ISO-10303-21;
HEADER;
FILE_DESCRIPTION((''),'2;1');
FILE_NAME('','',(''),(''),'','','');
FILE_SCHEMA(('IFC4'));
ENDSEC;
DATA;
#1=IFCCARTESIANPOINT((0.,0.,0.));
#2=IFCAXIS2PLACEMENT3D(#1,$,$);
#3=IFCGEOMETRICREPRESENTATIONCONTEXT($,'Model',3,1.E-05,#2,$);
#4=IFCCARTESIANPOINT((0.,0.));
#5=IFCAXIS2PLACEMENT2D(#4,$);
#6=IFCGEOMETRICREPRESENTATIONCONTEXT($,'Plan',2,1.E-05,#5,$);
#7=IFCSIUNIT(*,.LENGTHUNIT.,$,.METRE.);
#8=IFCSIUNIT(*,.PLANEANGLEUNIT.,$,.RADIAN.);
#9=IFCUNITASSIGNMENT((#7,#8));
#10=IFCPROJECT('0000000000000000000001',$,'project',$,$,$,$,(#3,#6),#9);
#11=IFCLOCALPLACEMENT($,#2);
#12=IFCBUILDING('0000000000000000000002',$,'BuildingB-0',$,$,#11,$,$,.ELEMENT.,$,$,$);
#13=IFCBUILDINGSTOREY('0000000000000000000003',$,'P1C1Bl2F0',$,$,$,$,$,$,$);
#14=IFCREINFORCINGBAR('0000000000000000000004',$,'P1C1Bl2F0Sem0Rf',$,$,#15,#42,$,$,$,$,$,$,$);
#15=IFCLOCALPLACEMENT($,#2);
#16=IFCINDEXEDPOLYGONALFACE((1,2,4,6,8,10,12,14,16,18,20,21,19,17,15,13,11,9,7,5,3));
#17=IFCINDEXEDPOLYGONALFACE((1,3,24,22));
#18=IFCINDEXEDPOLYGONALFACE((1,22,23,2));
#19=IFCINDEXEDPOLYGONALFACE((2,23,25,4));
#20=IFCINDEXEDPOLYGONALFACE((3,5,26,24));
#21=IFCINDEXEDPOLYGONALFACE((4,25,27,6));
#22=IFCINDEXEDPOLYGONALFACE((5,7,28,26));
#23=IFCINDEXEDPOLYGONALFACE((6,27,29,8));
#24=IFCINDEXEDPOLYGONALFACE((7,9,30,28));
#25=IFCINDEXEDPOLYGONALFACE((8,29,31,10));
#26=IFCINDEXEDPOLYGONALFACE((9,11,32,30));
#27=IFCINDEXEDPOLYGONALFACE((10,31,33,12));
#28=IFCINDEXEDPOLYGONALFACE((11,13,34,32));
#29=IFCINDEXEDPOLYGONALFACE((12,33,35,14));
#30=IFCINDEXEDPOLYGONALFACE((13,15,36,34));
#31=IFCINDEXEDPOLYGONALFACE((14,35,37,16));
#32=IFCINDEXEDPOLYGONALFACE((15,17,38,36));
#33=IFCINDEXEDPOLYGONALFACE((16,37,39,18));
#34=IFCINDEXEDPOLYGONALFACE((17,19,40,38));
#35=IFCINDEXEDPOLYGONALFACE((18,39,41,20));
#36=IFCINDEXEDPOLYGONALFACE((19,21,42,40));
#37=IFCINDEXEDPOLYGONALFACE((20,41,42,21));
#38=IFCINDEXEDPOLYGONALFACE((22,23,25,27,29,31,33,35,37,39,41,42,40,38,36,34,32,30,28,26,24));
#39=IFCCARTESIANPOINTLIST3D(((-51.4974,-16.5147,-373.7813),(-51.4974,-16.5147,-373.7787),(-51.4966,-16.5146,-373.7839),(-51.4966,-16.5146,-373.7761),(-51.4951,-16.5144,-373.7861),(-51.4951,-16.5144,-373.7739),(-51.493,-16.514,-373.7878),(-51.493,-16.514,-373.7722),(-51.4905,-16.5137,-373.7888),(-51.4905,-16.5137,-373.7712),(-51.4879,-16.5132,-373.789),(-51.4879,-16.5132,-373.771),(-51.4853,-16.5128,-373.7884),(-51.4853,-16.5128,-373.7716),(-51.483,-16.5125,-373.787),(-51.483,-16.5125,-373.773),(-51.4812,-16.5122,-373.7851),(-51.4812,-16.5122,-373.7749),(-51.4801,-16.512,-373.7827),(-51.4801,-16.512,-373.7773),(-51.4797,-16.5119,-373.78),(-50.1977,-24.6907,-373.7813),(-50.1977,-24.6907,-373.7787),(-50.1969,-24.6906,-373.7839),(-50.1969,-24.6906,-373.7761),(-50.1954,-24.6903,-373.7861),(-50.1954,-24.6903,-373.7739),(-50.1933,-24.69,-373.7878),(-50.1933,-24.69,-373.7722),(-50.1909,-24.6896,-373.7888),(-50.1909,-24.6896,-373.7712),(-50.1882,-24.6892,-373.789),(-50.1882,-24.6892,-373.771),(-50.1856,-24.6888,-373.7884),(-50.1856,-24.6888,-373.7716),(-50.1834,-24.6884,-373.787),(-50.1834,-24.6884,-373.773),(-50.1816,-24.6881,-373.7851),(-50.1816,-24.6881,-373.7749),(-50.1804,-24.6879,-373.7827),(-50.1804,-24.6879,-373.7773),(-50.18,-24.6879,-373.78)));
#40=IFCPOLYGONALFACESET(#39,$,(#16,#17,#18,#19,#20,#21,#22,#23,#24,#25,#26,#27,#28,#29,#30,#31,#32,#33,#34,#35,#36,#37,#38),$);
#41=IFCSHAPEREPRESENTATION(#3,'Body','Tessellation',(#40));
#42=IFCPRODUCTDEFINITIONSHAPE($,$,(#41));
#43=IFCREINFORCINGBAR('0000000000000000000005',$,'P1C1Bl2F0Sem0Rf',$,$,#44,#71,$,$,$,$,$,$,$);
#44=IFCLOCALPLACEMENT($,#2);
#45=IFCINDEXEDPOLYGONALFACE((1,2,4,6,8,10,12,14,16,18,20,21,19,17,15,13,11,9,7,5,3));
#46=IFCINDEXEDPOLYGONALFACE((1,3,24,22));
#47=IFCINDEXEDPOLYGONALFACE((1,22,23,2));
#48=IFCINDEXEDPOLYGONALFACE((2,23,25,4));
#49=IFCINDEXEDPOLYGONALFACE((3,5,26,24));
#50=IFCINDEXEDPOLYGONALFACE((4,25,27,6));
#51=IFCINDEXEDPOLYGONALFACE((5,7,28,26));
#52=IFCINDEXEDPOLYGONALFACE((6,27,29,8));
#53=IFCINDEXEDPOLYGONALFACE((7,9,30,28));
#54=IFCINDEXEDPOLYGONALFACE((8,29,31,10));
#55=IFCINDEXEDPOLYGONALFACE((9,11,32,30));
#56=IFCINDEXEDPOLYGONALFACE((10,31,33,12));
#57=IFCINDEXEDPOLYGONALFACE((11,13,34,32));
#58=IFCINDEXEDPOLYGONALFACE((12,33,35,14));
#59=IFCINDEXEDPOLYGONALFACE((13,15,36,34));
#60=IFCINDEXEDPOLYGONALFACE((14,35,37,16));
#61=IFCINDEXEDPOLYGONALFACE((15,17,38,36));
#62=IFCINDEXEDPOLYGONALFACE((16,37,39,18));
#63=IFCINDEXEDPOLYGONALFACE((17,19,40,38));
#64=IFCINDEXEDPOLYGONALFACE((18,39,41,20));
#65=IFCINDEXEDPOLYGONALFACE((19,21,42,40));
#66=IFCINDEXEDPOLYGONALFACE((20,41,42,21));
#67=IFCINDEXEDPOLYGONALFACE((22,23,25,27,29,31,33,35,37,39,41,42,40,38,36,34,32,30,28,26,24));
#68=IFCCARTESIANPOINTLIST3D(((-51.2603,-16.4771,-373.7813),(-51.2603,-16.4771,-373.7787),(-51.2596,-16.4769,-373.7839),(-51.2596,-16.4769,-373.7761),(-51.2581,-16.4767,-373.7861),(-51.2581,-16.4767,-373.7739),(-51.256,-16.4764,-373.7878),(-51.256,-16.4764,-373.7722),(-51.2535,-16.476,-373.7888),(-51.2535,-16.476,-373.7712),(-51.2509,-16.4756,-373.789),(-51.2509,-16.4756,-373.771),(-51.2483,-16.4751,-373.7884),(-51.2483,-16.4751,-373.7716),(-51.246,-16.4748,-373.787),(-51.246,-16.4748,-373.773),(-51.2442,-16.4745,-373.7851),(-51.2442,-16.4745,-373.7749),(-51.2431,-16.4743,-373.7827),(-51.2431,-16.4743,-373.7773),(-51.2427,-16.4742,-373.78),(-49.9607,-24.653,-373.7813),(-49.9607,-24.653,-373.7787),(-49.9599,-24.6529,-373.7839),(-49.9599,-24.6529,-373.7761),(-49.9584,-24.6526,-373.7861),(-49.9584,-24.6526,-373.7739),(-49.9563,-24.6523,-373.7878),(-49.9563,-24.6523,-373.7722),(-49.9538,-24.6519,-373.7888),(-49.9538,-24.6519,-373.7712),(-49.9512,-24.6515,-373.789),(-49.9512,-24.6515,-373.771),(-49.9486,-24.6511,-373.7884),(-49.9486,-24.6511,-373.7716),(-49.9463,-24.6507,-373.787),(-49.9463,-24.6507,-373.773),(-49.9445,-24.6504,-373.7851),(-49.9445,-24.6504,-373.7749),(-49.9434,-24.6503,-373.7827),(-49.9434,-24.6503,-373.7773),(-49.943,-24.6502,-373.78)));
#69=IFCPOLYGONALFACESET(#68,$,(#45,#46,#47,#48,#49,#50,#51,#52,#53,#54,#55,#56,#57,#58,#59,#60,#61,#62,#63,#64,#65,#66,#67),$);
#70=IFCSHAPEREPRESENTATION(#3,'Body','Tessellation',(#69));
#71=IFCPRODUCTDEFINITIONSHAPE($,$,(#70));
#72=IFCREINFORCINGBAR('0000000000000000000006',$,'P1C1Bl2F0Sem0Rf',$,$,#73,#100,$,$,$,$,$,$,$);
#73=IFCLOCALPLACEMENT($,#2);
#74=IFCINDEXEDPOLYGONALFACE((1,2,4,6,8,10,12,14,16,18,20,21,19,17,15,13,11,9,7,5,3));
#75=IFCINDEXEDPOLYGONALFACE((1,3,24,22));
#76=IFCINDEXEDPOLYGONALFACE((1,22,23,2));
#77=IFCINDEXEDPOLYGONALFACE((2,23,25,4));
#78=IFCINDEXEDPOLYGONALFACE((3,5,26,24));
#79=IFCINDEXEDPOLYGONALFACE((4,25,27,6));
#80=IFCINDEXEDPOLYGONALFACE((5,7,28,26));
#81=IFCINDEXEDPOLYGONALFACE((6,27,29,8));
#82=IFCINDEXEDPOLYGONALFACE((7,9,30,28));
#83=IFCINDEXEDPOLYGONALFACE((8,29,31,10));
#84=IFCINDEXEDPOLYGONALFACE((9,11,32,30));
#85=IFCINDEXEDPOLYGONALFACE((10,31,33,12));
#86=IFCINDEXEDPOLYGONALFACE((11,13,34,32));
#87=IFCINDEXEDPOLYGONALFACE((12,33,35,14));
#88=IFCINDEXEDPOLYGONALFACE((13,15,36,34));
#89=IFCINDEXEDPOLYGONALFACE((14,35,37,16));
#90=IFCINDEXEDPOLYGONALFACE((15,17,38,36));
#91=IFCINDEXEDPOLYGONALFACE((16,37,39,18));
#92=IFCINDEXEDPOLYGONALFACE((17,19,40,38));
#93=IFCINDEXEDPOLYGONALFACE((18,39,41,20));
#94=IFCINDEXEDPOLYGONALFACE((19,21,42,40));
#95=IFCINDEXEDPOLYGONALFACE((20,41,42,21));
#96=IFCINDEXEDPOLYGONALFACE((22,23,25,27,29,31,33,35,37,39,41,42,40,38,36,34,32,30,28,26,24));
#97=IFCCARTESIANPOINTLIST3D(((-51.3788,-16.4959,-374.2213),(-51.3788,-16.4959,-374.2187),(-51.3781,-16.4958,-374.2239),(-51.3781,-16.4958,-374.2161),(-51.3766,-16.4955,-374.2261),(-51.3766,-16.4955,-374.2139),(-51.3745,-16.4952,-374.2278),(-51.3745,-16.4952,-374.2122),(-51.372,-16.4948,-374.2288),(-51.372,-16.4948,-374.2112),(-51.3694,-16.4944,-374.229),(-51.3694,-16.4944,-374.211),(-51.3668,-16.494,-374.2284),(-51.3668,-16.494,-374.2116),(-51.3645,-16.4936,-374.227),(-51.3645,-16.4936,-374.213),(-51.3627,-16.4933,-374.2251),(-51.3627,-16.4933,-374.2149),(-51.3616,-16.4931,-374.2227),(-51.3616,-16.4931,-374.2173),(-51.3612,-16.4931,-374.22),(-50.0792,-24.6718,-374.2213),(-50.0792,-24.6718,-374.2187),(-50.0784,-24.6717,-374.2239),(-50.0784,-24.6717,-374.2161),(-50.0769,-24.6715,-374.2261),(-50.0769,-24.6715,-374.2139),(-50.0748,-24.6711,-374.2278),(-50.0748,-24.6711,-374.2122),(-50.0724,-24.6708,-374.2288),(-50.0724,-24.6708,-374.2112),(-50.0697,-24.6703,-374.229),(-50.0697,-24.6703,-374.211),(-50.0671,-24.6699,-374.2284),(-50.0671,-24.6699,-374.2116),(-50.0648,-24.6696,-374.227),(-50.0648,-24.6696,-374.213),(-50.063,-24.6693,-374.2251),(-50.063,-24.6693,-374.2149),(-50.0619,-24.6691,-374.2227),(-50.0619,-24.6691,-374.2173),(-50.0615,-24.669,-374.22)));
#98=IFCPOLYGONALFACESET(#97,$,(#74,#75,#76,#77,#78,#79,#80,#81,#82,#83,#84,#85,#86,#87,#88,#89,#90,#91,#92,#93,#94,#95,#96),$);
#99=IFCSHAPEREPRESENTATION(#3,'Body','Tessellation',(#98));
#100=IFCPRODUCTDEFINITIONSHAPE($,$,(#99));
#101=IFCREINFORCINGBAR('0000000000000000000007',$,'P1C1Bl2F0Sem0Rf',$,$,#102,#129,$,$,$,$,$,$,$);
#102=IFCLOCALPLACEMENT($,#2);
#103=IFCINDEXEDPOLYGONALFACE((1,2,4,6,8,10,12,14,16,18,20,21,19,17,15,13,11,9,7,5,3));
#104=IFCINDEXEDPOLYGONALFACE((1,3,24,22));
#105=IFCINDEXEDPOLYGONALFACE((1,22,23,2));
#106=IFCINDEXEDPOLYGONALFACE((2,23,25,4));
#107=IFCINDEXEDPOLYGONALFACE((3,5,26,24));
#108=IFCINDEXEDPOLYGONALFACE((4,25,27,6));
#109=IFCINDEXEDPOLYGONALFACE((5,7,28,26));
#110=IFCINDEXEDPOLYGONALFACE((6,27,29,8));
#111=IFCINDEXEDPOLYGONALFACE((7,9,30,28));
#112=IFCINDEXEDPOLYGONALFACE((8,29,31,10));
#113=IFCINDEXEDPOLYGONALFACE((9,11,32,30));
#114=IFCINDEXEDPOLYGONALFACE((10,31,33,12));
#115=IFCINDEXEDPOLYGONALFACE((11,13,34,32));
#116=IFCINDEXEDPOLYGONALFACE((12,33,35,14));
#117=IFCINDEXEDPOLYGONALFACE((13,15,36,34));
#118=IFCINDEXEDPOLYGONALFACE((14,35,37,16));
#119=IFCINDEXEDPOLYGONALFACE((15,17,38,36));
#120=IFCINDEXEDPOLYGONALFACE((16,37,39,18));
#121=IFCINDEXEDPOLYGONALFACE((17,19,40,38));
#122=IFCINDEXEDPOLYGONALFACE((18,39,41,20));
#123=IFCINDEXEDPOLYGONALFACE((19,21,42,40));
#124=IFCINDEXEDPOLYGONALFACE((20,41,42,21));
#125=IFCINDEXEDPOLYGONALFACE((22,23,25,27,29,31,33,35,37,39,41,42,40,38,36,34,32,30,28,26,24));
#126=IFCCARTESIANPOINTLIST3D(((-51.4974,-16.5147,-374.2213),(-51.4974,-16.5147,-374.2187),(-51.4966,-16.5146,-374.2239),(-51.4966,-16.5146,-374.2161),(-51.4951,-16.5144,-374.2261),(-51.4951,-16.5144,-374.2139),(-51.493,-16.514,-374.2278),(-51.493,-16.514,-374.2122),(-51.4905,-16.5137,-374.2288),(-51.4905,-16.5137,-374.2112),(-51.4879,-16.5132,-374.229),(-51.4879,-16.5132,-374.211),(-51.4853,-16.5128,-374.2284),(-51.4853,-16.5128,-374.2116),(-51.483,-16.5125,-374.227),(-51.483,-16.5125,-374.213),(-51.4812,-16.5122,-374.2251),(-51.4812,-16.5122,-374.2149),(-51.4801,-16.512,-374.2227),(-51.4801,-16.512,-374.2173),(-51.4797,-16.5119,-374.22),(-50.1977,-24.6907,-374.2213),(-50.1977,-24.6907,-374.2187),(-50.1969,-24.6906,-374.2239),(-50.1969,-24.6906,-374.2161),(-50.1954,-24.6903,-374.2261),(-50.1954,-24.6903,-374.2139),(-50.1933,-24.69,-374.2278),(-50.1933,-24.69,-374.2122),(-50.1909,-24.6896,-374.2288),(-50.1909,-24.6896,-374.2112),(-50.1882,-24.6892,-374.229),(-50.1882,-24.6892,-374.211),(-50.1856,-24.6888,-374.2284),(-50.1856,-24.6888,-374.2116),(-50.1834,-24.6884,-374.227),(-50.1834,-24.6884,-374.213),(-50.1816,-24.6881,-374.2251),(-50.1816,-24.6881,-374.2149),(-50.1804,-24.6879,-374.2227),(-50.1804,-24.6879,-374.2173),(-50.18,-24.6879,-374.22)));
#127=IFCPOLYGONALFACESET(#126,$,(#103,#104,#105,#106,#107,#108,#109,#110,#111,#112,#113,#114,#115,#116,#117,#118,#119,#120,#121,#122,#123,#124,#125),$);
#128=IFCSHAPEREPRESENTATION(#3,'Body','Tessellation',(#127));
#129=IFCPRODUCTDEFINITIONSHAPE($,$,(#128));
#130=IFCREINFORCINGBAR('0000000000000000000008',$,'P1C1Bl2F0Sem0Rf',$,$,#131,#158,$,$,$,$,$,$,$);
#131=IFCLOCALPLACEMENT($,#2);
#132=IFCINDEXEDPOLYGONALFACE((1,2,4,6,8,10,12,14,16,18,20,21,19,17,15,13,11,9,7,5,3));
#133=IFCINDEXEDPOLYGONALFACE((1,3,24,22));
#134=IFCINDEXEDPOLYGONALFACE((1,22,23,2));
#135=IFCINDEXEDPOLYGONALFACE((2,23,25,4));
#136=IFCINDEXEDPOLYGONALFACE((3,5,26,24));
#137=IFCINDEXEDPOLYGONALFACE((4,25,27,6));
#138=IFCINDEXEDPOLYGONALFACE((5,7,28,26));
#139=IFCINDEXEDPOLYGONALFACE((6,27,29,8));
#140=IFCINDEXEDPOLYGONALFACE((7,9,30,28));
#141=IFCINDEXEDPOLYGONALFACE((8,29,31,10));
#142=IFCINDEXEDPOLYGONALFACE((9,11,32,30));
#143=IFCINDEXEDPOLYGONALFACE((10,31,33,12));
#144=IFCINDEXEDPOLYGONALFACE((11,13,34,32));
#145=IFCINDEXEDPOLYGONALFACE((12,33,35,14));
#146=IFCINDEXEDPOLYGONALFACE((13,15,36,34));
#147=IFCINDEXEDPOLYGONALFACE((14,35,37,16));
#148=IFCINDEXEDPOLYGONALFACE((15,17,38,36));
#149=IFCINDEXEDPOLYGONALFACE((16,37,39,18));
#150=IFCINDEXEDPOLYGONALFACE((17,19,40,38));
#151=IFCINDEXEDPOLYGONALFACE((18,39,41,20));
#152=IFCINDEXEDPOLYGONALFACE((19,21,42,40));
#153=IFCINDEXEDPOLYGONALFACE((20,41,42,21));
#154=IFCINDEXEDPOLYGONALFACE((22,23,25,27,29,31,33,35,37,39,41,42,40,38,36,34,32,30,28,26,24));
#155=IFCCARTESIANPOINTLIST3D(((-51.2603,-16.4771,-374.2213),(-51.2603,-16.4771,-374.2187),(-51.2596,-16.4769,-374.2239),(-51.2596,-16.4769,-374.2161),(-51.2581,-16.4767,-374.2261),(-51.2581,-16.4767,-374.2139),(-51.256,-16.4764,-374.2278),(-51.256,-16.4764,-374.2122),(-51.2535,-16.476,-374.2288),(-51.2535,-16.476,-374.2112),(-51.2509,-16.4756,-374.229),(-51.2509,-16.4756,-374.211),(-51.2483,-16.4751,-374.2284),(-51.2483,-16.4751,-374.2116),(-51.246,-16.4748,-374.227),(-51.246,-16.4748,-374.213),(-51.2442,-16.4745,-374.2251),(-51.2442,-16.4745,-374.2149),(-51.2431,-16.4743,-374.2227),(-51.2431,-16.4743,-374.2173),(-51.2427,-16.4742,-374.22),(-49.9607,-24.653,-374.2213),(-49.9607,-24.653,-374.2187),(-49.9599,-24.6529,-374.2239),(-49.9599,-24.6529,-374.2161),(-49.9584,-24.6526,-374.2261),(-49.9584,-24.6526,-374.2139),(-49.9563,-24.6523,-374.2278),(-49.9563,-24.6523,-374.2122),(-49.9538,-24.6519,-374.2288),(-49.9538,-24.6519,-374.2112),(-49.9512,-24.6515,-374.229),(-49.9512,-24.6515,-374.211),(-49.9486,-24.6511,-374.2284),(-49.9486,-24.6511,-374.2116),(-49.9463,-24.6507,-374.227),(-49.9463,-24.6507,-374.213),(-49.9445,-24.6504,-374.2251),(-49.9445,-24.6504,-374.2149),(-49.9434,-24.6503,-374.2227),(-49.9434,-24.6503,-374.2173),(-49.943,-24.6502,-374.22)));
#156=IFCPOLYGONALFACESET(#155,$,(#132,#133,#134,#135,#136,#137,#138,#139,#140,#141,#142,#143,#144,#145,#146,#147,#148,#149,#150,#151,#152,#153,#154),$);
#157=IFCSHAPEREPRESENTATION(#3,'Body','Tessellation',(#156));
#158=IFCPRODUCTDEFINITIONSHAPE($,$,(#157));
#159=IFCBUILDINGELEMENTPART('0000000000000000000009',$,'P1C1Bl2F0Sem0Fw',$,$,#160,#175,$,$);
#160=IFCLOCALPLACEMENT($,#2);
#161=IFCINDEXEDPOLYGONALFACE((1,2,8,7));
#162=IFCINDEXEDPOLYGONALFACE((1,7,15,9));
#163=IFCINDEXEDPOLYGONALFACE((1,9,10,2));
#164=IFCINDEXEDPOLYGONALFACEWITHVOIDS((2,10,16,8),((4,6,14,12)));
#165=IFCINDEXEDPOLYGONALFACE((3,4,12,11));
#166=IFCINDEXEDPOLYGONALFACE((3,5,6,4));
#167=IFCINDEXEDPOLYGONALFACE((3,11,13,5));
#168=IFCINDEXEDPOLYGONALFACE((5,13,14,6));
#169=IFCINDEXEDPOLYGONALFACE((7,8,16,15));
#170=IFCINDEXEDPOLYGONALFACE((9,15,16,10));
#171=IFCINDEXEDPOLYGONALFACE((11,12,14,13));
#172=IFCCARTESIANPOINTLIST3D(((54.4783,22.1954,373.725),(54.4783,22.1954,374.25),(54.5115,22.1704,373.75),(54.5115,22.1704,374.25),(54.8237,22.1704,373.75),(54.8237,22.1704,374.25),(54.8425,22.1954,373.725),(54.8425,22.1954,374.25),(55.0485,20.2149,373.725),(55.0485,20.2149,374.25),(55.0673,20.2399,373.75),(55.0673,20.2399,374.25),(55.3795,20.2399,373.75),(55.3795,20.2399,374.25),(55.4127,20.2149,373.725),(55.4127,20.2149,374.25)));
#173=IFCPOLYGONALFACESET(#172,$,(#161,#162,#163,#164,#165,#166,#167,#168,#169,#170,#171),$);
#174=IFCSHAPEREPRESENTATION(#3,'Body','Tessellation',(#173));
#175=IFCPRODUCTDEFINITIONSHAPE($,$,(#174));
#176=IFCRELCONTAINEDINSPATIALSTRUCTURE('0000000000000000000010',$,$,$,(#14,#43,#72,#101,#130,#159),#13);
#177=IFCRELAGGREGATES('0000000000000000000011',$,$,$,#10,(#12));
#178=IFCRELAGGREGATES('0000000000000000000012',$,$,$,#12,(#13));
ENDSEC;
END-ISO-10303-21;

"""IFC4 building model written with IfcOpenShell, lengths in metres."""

from ifc_helpers import new_model, entity, si_unit, origin, origin_2d, place, context, project, spatial, polyline, outline, extrude, element, save


model = new_model("IFC4")

# Units and contexts
model_context = context("Model", 3, precision=1e-05, world=origin())
plan_context = context("Plan", 2, precision=1e-05, world=origin_2d())
ifc_project = project(units=[si_unit("LENGTHUNIT", "METRE"), si_unit("PLANEANGLEUNIT", "RADIAN")], contexts=[model_context, plan_context])

# Building, storey
building_placement = place(None, origin())
building = spatial("IfcBuilding", under=ifc_project, at=building_placement, Name="BuildingB-0", CompositionType="ELEMENT")
storey = spatial("IfcBuildingStorey", under=building, Name="P1C1Bl2F0")

# Reinforcing bars
element("IfcReinforcingBar", 1, inside=storey, Name="P1C1Bl2F0Sem0Rf", context=model_context, shape_type="SweptSolid", body=[
    entity("IfcSurfaceCurveSweptAreaSolid", entity("IfcCircleProfileDef", "AREA", None, None, 0.009), None, entity("IfcPolyline", [entity("IfcCartesianPoint", [51.4886, 16.5133, 373.78]), entity("IfcCartesianPoint", [50.1889, 24.6893, 373.78])]), None, None, entity("IfcPlane", entity("IfcAxis2Placement3D", entity("IfcCartesianPoint", [51.4886, 16.5133, 373.78]), entity("IfcDirection", [0.0, 0.0, 1.0]), entity("IfcDirection", [1.0, 0.0, 0.0])))),
])
element("IfcReinforcingBar", 2, inside=storey, Name="P1C1Bl2F0Sem0Rf", context=model_context, shape_type="SweptSolid", body=[
    entity("IfcSurfaceCurveSweptAreaSolid", entity("IfcCircleProfileDef", "AREA", None, None, 0.009), None, entity("IfcPolyline", [entity("IfcCartesianPoint", [51.2515, 16.4757, 373.78]), entity("IfcCartesianPoint", [49.9519, 24.6516, 373.78])]), None, None, entity("IfcPlane", entity("IfcAxis2Placement3D", entity("IfcCartesianPoint", [51.2515, 16.4757, 373.78]), entity("IfcDirection", [0.0, 0.0, 1.0]), entity("IfcDirection", [1.0, 0.0, 0.0])))),
])
element("IfcReinforcingBar", 3, inside=storey, Name="P1C1Bl2F0Sem0Rf", context=model_context, shape_type="SweptSolid", body=[
    entity("IfcSurfaceCurveSweptAreaSolid", entity("IfcCircleProfileDef", "AREA", None, None, 0.009), None, entity("IfcPolyline", [entity("IfcCartesianPoint", [51.3701, 16.4945, 374.22]), entity("IfcCartesianPoint", [50.0704, 24.6704, 374.22])]), None, None, entity("IfcPlane", entity("IfcAxis2Placement3D", entity("IfcCartesianPoint", [51.3701, 16.4945, 374.22]), entity("IfcDirection", [0.0, 0.0, 1.0]), entity("IfcDirection", [1.0, 0.0, 0.0])))),
])
element("IfcReinforcingBar", 4, inside=storey, Name="P1C1Bl2F0Sem0Rf", context=model_context, shape_type="SweptSolid", body=[
    entity("IfcSurfaceCurveSweptAreaSolid", entity("IfcCircleProfileDef", "AREA", None, None, 0.009), None, entity("IfcPolyline", [entity("IfcCartesianPoint", [51.4886, 16.5133, 374.22]), entity("IfcCartesianPoint", [50.1889, 24.6893, 374.22])]), None, None, entity("IfcPlane", entity("IfcAxis2Placement3D", entity("IfcCartesianPoint", [51.4886, 16.5133, 374.22]), entity("IfcDirection", [0.0, 0.0, 1.0]), entity("IfcDirection", [1.0, 0.0, 0.0])))),
])
element("IfcReinforcingBar", 5, inside=storey, Name="P1C1Bl2F0Sem0Rf", context=model_context, shape_type="SweptSolid", body=[
    entity("IfcSurfaceCurveSweptAreaSolid", entity("IfcCircleProfileDef", "AREA", None, None, 0.009), None, entity("IfcPolyline", [entity("IfcCartesianPoint", [51.2515, 16.4757, 374.22]), entity("IfcCartesianPoint", [49.9519, 24.6516, 374.22])]), None, None, entity("IfcPlane", entity("IfcAxis2Placement3D", entity("IfcCartesianPoint", [51.2515, 16.4757, 374.22]), entity("IfcDirection", [0.0, 0.0, 1.0]), entity("IfcDirection", [1.0, 0.0, 0.0])))),
])

# Building element part, opening
building_element_part_1 = element("IfcBuildingElementPart", 6, inside=storey, Name="P1C1Bl2F0Sem0Fw", context=model_context, shape_type="SweptSolid", body=[
    extrude(outline(polyline([(55.0485, 20.2149, 373.725), (55.4127, 20.2149, 373.725), (54.8425, 22.1954, 373.725), (54.4783, 22.1954, 373.725), (55.0485, 20.2149, 373.725)])), None, (0.0, 0.0, 1.0), 0.525),
])
element("IfcOpeningElement", 7, inside=storey, cuts=building_element_part_1, context=model_context, shape_type="SweptSolid", body=[
    extrude(outline(polyline([(55.0673, 20.2399, 373.75), (55.3795, 20.2399, 373.75), (54.8237, 22.1704, 373.75), (54.5115, 22.1704, 373.75), (55.0673, 20.2399, 373.75)])), None, (0.0, 0.0, 1.0), 0.5),
])

save(model, "model.ifc")
